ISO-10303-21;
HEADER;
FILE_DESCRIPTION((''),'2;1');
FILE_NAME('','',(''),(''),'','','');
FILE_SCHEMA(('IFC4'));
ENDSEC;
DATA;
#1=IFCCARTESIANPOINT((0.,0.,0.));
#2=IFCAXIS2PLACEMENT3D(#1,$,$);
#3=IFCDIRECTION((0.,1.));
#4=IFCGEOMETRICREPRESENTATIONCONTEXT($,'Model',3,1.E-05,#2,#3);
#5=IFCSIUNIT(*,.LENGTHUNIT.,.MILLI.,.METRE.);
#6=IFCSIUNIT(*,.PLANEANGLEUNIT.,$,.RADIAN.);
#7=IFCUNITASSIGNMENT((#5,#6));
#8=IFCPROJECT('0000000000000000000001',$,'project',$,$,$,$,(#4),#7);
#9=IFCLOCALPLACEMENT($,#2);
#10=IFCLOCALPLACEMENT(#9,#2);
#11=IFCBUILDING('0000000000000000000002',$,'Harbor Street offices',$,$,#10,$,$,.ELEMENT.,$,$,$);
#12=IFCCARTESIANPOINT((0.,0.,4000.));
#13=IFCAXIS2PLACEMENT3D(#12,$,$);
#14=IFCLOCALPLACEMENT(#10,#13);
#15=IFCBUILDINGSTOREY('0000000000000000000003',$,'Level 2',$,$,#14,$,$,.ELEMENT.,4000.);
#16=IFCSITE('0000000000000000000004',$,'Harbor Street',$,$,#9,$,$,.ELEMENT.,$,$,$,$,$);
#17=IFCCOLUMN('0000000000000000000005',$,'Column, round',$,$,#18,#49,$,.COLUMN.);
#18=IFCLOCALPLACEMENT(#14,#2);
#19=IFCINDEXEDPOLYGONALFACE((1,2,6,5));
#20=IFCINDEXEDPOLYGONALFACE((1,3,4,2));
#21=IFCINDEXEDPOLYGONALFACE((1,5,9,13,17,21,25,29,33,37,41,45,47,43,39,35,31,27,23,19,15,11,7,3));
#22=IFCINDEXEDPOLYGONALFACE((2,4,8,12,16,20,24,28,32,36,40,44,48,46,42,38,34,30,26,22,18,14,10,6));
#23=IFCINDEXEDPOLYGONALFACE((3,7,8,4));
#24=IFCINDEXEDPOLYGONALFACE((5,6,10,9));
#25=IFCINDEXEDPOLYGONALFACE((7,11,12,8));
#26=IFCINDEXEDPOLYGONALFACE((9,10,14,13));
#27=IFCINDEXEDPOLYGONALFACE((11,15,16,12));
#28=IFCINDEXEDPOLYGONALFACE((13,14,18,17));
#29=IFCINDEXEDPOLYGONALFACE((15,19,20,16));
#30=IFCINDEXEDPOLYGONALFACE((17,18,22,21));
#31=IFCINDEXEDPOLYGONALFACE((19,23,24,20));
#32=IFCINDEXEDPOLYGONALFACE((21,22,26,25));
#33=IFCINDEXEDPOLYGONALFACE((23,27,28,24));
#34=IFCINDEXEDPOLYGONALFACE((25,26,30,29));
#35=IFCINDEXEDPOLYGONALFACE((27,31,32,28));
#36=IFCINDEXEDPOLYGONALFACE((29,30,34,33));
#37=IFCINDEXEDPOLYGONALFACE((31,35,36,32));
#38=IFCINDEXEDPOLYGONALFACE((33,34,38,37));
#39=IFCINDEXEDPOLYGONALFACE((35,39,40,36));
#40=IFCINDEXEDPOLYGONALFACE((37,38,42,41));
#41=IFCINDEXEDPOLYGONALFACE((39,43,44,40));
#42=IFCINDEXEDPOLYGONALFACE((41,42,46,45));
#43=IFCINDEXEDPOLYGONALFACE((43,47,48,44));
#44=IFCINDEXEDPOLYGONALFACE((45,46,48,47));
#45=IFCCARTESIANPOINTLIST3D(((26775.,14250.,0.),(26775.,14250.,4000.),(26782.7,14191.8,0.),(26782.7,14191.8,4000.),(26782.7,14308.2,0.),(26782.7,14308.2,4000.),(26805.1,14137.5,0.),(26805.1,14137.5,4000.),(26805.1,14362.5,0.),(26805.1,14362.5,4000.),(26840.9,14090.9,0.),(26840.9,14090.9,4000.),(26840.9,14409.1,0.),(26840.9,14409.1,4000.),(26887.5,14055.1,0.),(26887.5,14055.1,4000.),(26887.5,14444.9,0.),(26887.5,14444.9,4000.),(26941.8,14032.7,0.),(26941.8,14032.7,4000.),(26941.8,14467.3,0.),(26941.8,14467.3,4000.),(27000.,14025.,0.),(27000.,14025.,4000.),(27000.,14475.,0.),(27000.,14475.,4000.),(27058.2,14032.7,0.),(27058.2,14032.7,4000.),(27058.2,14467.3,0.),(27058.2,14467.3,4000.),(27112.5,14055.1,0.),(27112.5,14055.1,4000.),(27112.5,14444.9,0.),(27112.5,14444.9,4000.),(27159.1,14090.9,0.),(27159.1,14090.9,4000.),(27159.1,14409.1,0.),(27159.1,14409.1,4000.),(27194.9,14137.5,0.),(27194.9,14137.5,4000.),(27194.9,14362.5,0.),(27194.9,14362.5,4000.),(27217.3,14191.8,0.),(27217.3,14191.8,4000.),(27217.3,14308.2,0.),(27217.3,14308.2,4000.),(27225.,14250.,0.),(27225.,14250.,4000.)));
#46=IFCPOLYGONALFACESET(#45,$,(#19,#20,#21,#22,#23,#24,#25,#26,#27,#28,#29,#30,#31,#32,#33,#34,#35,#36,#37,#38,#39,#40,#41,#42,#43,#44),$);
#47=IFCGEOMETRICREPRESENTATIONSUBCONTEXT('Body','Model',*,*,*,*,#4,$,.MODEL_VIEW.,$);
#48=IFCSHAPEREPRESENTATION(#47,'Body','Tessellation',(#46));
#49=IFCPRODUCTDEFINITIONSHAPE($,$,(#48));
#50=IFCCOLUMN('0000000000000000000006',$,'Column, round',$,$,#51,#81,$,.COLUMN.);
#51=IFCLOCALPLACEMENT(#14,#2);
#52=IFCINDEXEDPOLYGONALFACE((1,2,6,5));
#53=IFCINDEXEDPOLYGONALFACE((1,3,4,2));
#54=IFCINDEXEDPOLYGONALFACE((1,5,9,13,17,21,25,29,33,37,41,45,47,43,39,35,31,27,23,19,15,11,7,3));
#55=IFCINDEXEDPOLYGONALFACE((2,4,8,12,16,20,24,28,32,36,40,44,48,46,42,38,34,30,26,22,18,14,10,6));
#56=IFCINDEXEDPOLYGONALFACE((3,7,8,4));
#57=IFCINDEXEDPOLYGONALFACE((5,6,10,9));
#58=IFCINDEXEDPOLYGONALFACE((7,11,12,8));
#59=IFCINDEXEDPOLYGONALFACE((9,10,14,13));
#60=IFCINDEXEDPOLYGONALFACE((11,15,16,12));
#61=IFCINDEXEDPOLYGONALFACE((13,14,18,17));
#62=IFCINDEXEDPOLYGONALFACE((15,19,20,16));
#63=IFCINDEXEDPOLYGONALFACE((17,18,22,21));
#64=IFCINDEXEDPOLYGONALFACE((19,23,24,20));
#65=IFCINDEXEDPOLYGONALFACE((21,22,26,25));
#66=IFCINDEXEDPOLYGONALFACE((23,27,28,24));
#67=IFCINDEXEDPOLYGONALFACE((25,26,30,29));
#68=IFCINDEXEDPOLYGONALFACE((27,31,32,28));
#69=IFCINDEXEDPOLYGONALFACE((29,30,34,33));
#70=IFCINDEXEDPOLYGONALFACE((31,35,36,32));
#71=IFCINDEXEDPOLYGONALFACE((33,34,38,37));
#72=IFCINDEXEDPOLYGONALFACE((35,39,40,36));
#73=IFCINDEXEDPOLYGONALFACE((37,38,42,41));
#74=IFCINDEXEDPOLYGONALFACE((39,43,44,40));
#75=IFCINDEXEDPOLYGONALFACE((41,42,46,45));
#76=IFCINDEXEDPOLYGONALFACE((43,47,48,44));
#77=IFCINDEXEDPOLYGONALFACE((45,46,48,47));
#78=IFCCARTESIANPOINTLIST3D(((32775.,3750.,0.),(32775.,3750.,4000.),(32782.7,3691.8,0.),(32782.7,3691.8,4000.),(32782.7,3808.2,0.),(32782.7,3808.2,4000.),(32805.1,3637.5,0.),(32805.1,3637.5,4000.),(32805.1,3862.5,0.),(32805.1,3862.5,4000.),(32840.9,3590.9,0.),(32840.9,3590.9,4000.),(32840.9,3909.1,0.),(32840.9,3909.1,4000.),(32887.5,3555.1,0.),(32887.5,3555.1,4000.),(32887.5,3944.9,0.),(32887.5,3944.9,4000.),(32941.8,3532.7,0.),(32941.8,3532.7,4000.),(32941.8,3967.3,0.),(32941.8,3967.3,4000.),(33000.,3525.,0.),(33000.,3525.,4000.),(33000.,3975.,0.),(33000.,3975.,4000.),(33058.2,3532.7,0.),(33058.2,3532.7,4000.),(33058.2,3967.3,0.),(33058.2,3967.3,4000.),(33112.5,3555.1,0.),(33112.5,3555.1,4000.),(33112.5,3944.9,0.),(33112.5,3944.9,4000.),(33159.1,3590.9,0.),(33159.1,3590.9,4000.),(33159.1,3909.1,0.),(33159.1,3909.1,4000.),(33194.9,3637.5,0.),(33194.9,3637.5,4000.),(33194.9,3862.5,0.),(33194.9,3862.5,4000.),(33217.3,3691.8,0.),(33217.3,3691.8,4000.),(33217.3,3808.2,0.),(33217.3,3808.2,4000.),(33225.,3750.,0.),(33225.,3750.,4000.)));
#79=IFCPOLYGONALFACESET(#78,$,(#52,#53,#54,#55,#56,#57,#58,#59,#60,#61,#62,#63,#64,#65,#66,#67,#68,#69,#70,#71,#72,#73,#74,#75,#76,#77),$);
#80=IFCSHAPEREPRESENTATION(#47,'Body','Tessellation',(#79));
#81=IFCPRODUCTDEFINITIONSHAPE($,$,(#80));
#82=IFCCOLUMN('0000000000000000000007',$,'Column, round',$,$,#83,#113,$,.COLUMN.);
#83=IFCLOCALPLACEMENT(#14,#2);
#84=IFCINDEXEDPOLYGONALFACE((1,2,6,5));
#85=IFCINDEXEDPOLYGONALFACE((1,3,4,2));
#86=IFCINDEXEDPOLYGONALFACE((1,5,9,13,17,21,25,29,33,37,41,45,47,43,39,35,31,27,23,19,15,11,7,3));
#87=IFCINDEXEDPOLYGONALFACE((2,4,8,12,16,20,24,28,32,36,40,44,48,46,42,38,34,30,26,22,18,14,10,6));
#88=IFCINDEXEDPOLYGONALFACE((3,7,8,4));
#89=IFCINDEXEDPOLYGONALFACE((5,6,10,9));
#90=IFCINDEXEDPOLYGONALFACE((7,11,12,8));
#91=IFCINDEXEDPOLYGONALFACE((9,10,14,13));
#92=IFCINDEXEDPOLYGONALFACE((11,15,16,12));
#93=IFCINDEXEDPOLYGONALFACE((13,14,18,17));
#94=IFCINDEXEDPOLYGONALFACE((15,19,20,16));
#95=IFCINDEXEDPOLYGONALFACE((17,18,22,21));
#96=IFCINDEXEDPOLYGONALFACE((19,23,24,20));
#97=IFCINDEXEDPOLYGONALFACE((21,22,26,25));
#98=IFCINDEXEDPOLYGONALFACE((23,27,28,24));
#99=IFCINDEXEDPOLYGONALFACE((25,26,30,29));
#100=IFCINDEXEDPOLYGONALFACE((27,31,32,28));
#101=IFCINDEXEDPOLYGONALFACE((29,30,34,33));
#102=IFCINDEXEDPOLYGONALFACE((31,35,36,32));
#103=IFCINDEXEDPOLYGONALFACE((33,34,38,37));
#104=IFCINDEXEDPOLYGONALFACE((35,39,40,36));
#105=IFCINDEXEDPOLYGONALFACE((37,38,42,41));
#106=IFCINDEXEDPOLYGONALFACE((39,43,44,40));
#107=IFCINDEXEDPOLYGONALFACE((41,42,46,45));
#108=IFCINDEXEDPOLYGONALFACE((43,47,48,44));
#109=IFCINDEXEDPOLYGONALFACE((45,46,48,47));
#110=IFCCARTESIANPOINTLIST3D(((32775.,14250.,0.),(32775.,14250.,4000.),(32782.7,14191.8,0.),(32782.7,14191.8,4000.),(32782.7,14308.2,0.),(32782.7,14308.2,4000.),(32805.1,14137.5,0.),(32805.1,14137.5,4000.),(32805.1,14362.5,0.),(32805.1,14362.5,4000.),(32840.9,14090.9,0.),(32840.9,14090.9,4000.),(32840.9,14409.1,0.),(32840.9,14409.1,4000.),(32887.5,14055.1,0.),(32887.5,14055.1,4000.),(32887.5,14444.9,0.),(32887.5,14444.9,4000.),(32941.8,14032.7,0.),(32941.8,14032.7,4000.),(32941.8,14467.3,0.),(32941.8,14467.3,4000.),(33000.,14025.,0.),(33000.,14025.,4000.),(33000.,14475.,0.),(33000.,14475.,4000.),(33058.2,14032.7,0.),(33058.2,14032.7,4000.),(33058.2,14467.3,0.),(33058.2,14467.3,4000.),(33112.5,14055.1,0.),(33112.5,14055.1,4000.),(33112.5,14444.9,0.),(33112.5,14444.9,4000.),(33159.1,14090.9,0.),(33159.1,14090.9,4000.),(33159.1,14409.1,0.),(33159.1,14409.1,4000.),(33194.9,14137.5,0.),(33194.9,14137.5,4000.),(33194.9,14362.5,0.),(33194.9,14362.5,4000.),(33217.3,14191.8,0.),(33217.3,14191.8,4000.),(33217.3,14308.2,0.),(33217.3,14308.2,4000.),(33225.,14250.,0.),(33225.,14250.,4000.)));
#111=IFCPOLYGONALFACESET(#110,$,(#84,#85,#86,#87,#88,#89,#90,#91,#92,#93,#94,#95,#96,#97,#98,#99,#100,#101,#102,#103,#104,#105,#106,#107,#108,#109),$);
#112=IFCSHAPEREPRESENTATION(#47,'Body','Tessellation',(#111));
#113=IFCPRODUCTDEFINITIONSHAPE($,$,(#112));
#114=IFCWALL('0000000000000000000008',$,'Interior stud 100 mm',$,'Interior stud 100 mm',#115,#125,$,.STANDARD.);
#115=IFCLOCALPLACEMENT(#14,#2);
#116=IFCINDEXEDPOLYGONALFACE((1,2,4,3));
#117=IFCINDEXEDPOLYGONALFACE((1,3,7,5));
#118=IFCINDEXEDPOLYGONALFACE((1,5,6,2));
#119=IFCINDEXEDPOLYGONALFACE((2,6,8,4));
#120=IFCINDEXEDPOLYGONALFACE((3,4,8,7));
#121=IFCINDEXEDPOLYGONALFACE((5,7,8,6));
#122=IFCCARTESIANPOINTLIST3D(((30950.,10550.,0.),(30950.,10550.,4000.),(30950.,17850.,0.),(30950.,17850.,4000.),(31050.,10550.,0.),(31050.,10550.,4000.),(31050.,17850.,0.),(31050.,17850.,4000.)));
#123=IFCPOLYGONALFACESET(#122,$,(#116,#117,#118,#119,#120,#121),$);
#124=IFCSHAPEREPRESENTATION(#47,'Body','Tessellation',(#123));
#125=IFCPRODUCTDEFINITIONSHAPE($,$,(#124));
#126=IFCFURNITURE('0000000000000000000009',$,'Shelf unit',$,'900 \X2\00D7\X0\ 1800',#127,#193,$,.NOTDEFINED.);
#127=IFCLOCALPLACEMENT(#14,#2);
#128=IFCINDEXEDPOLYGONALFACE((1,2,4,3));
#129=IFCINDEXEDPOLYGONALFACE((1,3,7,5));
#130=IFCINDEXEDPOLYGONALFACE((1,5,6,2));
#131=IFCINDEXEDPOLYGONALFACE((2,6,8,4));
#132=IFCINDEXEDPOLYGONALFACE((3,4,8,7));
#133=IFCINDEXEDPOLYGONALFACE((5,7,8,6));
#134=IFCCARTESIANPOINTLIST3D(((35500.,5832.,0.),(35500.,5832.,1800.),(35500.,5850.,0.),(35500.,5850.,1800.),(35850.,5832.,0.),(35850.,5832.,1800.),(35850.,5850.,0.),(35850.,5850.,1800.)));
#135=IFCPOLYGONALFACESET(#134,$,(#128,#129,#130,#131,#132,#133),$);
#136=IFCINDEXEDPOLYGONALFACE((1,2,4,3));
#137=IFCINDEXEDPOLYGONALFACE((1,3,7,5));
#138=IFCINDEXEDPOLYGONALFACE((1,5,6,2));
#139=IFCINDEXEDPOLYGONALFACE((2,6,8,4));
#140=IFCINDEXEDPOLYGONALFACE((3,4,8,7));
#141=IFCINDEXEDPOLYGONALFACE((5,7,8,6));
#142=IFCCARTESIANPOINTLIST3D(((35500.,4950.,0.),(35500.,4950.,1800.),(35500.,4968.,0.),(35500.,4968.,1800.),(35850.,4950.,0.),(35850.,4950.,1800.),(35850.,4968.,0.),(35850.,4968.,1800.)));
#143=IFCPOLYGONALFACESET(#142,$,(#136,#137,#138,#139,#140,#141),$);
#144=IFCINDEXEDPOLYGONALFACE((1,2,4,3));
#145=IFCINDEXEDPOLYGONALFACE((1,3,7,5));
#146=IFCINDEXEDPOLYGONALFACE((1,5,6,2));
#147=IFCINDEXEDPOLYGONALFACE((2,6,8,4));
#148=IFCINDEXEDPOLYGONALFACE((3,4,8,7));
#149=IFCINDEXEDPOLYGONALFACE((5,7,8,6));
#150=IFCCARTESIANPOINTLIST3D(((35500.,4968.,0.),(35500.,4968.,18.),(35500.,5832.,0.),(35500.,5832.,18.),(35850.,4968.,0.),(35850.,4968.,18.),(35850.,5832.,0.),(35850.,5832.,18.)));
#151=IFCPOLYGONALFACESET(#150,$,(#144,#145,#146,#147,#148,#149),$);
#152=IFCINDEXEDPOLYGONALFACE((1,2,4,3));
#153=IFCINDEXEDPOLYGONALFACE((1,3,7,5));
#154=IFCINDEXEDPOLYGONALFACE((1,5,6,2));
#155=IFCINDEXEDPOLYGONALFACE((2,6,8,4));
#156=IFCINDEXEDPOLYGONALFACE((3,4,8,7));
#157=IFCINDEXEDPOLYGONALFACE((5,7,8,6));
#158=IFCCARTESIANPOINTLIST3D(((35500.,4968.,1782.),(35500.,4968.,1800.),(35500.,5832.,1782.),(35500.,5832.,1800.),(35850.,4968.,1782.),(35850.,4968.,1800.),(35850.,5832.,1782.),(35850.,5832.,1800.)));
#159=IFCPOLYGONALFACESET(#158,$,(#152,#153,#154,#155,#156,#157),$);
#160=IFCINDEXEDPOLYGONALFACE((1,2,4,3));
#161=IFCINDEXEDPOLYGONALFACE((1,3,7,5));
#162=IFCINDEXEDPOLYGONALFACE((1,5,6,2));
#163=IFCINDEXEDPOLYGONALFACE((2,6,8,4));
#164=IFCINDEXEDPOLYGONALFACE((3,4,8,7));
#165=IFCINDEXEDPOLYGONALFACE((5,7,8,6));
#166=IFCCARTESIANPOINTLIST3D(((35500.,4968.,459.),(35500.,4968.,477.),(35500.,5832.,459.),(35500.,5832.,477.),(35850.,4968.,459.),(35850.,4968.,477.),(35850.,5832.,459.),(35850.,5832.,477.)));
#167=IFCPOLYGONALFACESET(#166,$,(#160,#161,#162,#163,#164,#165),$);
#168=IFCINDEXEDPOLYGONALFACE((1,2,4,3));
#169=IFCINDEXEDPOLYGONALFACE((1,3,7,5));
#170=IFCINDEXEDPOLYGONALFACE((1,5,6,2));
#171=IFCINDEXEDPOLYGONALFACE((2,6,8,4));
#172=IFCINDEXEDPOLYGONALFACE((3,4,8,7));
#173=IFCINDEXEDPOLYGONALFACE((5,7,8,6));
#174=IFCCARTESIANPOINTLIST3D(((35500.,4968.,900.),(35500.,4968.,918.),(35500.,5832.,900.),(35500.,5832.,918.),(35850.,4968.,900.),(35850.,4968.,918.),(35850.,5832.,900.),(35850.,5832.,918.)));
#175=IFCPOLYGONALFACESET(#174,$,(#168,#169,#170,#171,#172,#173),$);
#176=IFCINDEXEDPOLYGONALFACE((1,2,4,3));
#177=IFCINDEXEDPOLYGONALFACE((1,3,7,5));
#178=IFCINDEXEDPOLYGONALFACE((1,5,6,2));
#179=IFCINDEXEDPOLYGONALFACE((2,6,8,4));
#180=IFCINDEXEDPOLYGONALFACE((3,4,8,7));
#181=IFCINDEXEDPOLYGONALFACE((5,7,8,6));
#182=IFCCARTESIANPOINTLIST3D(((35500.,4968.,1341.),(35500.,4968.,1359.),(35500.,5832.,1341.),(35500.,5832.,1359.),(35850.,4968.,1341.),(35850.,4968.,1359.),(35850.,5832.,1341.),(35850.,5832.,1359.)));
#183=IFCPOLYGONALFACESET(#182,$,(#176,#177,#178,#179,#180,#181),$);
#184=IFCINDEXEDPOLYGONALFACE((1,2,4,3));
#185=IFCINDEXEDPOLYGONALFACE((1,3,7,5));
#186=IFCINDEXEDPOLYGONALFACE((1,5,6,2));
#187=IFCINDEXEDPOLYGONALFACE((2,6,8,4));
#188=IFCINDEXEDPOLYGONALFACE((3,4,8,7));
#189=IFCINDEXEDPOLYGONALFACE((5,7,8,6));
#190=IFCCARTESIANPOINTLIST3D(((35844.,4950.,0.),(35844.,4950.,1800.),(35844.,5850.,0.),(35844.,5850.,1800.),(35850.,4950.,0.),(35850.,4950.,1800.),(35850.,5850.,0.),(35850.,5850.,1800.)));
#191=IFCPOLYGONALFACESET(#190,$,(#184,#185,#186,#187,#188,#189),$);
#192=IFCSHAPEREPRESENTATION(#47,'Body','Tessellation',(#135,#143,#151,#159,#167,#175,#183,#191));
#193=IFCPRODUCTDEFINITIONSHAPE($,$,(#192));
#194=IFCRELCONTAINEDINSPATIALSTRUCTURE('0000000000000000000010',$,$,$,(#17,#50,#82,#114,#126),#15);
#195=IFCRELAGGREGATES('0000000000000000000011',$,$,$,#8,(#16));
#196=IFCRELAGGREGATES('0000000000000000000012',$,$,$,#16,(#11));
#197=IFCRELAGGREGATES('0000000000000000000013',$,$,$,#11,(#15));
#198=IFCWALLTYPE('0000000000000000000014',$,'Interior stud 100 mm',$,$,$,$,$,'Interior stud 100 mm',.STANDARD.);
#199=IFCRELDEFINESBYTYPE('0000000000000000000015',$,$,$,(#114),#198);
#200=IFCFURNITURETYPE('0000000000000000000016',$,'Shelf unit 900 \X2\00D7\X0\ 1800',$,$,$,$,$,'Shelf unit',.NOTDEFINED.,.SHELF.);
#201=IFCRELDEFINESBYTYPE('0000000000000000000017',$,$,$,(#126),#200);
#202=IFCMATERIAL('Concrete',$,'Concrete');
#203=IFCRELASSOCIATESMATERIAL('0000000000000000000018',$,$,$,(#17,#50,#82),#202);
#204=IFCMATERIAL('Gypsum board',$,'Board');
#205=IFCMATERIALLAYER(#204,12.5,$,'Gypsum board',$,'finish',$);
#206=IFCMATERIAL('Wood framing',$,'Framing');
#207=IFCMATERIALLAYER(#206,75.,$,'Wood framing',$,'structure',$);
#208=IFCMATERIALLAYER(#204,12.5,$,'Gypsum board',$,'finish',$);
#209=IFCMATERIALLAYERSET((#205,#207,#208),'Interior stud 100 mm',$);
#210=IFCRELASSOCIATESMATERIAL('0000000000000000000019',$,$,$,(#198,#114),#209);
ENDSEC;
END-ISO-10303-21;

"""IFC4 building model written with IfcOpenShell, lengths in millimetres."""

from ifc_helpers import new_model, si_unit, direction, frame, origin, origin_2d, place, context, subcontext, project, spatial, polyline, circle, outline, extrude, source, transform, mapped, material, layer, layer_set, layer_usage, type_object, type_shapes, element, save


model = new_model("IFC4")

# Units and contexts
model_context = context("Model", 3, precision=1e-05, world=origin(), true_north=direction((0.0, 1.0)))
body_context = subcontext(model_context, "Body", "Model", "MODEL_VIEW")
ifc_project = project(units=[si_unit("LENGTHUNIT", "METRE", prefix="MILLI"), si_unit("PLANEANGLEUNIT", "RADIAN")], contexts=[model_context])

# Site, building, storey
site_placement = place(None, origin())
site = spatial("IfcSite", under=ifc_project, at=site_placement, Name="Harbor Street", CompositionType="ELEMENT")
building_placement = place(site_placement, origin())
building = spatial("IfcBuilding", under=site, at=building_placement, Name="Harbor Street offices", CompositionType="ELEMENT")
storey_placement = place(building_placement, frame((0.0, 0.0, 4000.0)))
storey = spatial("IfcBuildingStorey", under=building, at=storey_placement, Name="Level 2", CompositionType="ELEMENT", Elevation=4000.0)

# Columns
ifc_material_1 = material(Name="Concrete", Category="Concrete")
for number, where, z_axis, x_axis, name in (
    (1, (27000.0, 14250.0, 0.0), (0.0, 0.0, 1.0), (1.0, 0.0, 0.0), "Column, round"),
    (2, (33000.0, 3750.0, 0.0), (0.0, 0.0, 1.0), (1.0, 0.0, 0.0), "Column, round"),
    (3, (33000.0, 14250.0, 0.0), (0.0, 0.0, 1.0), (1.0, 0.0, 0.0), "Column, round"),
):
    element("IfcColumn", number, at=place(storey_placement, frame(where, z_axis=z_axis, x_axis=x_axis)), inside=storey, material=ifc_material_1, Name=name, PredefinedType="COLUMN", context=body_context, shape_type="SweptSolid", body=[
        extrude(circle(Radius=225.0, at=origin_2d()), origin(), (0.0, 0.0, 1.0), 4000.0),
    ])

# Wall
ifc_material_2 = material(Name="Gypsum board", Category="Board")
ifc_layer_1 = layer(ifc_material_2, 12.5, Name="Gypsum board", Category="finish")
ifc_material_3 = material(Name="Wood framing", Category="Framing")
ifc_layer_2 = layer(ifc_material_3, 75.0, Name="Wood framing", Category="structure")
ifc_layer_3 = layer(ifc_material_2, 12.5, Name="Gypsum board", Category="finish")
ifc_layer_set_1 = layer_set([ifc_layer_1, ifc_layer_2, ifc_layer_3], Name="Interior stud 100 mm")
ifc_layer_usage_1 = layer_usage(ifc_layer_set_1, "AXIS2", "NEGATIVE", 50.0)
wall_type_1 = type_object("IfcWallType", Name="Interior stud 100 mm", ElementType="Interior stud 100 mm", PredefinedType="STANDARD", material=ifc_layer_set_1)
wall_1_placement = place(storey_placement, frame((31000.0, 10500.0, 0.0), z_axis=(0.0, 0.0, 1.0), x_axis=(0.0, 1.0, 0.0)))
element("IfcWall", 4, at=wall_1_placement, inside=storey, type_object=wall_type_1, material=ifc_layer_usage_1, Name="Interior stud 100 mm", ObjectType="Interior stud 100 mm", PredefinedType="STANDARD", context=body_context, shape_type="SweptSolid", body=[
    extrude(outline(polyline([(50.0, -50.0), (7350.0, -50.0), (7350.0, 50.0), (50.0, 50.0), (50.0, -50.0)])), origin(), (0.0, 0.0, 1.0), 4000.0),
])

# Furniture
furniture_type_1 = type_object("IfcFurnitureType", Name="Shelf unit 900 × 1800", ElementType="Shelf unit", AssemblyPlace="NOTDEFINED", PredefinedType="SHELF")
shared_shape_1 = source(origin(), body_context, "Body", "SweptSolid", [
    extrude(outline(polyline([(-450.0, 0.0), (-432.0, 0.0), (-432.0, 350.0), (-450.0, 350.0), (-450.0, 0.0)])), origin(), (0.0, 0.0, 1.0), 1800.0),
    extrude(outline(polyline([(432.0, 0.0), (450.0, 0.0), (450.0, 350.0), (432.0, 350.0), (432.0, 0.0)])), origin(), (0.0, 0.0, 1.0), 1800.0),
    extrude(outline(polyline([(-432.0, 0.0), (432.0, 0.0), (432.0, 350.0), (-432.0, 350.0), (-432.0, 0.0)])), origin(), (0.0, 0.0, 1.0), 18.0),
    extrude(outline(polyline([(-432.0, 0.0), (432.0, 0.0), (432.0, 350.0), (-432.0, 350.0), (-432.0, 0.0)])), frame((0.0, 0.0, 1782.0)), (0.0, 0.0, 1.0), 18.0),
    extrude(outline(polyline([(-432.0, 0.0), (432.0, 0.0), (432.0, 350.0), (-432.0, 350.0), (-432.0, 0.0)])), frame((0.0, 0.0, 459.0)), (0.0, 0.0, 1.0), 18.0),
    extrude(outline(polyline([(-432.0, 0.0), (432.0, 0.0), (432.0, 350.0), (-432.0, 350.0), (-432.0, 0.0)])), frame((0.0, 0.0, 900.0)), (0.0, 0.0, 1.0), 18.0),
    extrude(outline(polyline([(-432.0, 0.0), (432.0, 0.0), (432.0, 350.0), (-432.0, 350.0), (-432.0, 0.0)])), frame((0.0, 0.0, 1341.0)), (0.0, 0.0, 1.0), 18.0),
    extrude(outline(polyline([(-450.0, 344.0), (450.0, 344.0), (450.0, 350.0), (-450.0, 350.0), (-450.0, 344.0)])), origin(), (0.0, 0.0, 1.0), 1800.0),
])
type_shapes(furniture_type_1, [shared_shape_1])
furniture_placement = place(storey_placement, frame((35500.0, 5400.0, 0.0), z_axis=(0.0, 0.0, 1.0), x_axis=(0.0, -1.0, 0.0)))
element("IfcFurniture", 5, at=furniture_placement, inside=storey, type_object=furniture_type_1, Name="Shelf unit", ObjectType="900 × 1800", PredefinedType="NOTDEFINED", context=body_context, shape_type="MappedRepresentation", body=[
    mapped(shared_shape_1, transform((0.0, 0.0, 0.0))),
])

save(model, "model.ifc")
